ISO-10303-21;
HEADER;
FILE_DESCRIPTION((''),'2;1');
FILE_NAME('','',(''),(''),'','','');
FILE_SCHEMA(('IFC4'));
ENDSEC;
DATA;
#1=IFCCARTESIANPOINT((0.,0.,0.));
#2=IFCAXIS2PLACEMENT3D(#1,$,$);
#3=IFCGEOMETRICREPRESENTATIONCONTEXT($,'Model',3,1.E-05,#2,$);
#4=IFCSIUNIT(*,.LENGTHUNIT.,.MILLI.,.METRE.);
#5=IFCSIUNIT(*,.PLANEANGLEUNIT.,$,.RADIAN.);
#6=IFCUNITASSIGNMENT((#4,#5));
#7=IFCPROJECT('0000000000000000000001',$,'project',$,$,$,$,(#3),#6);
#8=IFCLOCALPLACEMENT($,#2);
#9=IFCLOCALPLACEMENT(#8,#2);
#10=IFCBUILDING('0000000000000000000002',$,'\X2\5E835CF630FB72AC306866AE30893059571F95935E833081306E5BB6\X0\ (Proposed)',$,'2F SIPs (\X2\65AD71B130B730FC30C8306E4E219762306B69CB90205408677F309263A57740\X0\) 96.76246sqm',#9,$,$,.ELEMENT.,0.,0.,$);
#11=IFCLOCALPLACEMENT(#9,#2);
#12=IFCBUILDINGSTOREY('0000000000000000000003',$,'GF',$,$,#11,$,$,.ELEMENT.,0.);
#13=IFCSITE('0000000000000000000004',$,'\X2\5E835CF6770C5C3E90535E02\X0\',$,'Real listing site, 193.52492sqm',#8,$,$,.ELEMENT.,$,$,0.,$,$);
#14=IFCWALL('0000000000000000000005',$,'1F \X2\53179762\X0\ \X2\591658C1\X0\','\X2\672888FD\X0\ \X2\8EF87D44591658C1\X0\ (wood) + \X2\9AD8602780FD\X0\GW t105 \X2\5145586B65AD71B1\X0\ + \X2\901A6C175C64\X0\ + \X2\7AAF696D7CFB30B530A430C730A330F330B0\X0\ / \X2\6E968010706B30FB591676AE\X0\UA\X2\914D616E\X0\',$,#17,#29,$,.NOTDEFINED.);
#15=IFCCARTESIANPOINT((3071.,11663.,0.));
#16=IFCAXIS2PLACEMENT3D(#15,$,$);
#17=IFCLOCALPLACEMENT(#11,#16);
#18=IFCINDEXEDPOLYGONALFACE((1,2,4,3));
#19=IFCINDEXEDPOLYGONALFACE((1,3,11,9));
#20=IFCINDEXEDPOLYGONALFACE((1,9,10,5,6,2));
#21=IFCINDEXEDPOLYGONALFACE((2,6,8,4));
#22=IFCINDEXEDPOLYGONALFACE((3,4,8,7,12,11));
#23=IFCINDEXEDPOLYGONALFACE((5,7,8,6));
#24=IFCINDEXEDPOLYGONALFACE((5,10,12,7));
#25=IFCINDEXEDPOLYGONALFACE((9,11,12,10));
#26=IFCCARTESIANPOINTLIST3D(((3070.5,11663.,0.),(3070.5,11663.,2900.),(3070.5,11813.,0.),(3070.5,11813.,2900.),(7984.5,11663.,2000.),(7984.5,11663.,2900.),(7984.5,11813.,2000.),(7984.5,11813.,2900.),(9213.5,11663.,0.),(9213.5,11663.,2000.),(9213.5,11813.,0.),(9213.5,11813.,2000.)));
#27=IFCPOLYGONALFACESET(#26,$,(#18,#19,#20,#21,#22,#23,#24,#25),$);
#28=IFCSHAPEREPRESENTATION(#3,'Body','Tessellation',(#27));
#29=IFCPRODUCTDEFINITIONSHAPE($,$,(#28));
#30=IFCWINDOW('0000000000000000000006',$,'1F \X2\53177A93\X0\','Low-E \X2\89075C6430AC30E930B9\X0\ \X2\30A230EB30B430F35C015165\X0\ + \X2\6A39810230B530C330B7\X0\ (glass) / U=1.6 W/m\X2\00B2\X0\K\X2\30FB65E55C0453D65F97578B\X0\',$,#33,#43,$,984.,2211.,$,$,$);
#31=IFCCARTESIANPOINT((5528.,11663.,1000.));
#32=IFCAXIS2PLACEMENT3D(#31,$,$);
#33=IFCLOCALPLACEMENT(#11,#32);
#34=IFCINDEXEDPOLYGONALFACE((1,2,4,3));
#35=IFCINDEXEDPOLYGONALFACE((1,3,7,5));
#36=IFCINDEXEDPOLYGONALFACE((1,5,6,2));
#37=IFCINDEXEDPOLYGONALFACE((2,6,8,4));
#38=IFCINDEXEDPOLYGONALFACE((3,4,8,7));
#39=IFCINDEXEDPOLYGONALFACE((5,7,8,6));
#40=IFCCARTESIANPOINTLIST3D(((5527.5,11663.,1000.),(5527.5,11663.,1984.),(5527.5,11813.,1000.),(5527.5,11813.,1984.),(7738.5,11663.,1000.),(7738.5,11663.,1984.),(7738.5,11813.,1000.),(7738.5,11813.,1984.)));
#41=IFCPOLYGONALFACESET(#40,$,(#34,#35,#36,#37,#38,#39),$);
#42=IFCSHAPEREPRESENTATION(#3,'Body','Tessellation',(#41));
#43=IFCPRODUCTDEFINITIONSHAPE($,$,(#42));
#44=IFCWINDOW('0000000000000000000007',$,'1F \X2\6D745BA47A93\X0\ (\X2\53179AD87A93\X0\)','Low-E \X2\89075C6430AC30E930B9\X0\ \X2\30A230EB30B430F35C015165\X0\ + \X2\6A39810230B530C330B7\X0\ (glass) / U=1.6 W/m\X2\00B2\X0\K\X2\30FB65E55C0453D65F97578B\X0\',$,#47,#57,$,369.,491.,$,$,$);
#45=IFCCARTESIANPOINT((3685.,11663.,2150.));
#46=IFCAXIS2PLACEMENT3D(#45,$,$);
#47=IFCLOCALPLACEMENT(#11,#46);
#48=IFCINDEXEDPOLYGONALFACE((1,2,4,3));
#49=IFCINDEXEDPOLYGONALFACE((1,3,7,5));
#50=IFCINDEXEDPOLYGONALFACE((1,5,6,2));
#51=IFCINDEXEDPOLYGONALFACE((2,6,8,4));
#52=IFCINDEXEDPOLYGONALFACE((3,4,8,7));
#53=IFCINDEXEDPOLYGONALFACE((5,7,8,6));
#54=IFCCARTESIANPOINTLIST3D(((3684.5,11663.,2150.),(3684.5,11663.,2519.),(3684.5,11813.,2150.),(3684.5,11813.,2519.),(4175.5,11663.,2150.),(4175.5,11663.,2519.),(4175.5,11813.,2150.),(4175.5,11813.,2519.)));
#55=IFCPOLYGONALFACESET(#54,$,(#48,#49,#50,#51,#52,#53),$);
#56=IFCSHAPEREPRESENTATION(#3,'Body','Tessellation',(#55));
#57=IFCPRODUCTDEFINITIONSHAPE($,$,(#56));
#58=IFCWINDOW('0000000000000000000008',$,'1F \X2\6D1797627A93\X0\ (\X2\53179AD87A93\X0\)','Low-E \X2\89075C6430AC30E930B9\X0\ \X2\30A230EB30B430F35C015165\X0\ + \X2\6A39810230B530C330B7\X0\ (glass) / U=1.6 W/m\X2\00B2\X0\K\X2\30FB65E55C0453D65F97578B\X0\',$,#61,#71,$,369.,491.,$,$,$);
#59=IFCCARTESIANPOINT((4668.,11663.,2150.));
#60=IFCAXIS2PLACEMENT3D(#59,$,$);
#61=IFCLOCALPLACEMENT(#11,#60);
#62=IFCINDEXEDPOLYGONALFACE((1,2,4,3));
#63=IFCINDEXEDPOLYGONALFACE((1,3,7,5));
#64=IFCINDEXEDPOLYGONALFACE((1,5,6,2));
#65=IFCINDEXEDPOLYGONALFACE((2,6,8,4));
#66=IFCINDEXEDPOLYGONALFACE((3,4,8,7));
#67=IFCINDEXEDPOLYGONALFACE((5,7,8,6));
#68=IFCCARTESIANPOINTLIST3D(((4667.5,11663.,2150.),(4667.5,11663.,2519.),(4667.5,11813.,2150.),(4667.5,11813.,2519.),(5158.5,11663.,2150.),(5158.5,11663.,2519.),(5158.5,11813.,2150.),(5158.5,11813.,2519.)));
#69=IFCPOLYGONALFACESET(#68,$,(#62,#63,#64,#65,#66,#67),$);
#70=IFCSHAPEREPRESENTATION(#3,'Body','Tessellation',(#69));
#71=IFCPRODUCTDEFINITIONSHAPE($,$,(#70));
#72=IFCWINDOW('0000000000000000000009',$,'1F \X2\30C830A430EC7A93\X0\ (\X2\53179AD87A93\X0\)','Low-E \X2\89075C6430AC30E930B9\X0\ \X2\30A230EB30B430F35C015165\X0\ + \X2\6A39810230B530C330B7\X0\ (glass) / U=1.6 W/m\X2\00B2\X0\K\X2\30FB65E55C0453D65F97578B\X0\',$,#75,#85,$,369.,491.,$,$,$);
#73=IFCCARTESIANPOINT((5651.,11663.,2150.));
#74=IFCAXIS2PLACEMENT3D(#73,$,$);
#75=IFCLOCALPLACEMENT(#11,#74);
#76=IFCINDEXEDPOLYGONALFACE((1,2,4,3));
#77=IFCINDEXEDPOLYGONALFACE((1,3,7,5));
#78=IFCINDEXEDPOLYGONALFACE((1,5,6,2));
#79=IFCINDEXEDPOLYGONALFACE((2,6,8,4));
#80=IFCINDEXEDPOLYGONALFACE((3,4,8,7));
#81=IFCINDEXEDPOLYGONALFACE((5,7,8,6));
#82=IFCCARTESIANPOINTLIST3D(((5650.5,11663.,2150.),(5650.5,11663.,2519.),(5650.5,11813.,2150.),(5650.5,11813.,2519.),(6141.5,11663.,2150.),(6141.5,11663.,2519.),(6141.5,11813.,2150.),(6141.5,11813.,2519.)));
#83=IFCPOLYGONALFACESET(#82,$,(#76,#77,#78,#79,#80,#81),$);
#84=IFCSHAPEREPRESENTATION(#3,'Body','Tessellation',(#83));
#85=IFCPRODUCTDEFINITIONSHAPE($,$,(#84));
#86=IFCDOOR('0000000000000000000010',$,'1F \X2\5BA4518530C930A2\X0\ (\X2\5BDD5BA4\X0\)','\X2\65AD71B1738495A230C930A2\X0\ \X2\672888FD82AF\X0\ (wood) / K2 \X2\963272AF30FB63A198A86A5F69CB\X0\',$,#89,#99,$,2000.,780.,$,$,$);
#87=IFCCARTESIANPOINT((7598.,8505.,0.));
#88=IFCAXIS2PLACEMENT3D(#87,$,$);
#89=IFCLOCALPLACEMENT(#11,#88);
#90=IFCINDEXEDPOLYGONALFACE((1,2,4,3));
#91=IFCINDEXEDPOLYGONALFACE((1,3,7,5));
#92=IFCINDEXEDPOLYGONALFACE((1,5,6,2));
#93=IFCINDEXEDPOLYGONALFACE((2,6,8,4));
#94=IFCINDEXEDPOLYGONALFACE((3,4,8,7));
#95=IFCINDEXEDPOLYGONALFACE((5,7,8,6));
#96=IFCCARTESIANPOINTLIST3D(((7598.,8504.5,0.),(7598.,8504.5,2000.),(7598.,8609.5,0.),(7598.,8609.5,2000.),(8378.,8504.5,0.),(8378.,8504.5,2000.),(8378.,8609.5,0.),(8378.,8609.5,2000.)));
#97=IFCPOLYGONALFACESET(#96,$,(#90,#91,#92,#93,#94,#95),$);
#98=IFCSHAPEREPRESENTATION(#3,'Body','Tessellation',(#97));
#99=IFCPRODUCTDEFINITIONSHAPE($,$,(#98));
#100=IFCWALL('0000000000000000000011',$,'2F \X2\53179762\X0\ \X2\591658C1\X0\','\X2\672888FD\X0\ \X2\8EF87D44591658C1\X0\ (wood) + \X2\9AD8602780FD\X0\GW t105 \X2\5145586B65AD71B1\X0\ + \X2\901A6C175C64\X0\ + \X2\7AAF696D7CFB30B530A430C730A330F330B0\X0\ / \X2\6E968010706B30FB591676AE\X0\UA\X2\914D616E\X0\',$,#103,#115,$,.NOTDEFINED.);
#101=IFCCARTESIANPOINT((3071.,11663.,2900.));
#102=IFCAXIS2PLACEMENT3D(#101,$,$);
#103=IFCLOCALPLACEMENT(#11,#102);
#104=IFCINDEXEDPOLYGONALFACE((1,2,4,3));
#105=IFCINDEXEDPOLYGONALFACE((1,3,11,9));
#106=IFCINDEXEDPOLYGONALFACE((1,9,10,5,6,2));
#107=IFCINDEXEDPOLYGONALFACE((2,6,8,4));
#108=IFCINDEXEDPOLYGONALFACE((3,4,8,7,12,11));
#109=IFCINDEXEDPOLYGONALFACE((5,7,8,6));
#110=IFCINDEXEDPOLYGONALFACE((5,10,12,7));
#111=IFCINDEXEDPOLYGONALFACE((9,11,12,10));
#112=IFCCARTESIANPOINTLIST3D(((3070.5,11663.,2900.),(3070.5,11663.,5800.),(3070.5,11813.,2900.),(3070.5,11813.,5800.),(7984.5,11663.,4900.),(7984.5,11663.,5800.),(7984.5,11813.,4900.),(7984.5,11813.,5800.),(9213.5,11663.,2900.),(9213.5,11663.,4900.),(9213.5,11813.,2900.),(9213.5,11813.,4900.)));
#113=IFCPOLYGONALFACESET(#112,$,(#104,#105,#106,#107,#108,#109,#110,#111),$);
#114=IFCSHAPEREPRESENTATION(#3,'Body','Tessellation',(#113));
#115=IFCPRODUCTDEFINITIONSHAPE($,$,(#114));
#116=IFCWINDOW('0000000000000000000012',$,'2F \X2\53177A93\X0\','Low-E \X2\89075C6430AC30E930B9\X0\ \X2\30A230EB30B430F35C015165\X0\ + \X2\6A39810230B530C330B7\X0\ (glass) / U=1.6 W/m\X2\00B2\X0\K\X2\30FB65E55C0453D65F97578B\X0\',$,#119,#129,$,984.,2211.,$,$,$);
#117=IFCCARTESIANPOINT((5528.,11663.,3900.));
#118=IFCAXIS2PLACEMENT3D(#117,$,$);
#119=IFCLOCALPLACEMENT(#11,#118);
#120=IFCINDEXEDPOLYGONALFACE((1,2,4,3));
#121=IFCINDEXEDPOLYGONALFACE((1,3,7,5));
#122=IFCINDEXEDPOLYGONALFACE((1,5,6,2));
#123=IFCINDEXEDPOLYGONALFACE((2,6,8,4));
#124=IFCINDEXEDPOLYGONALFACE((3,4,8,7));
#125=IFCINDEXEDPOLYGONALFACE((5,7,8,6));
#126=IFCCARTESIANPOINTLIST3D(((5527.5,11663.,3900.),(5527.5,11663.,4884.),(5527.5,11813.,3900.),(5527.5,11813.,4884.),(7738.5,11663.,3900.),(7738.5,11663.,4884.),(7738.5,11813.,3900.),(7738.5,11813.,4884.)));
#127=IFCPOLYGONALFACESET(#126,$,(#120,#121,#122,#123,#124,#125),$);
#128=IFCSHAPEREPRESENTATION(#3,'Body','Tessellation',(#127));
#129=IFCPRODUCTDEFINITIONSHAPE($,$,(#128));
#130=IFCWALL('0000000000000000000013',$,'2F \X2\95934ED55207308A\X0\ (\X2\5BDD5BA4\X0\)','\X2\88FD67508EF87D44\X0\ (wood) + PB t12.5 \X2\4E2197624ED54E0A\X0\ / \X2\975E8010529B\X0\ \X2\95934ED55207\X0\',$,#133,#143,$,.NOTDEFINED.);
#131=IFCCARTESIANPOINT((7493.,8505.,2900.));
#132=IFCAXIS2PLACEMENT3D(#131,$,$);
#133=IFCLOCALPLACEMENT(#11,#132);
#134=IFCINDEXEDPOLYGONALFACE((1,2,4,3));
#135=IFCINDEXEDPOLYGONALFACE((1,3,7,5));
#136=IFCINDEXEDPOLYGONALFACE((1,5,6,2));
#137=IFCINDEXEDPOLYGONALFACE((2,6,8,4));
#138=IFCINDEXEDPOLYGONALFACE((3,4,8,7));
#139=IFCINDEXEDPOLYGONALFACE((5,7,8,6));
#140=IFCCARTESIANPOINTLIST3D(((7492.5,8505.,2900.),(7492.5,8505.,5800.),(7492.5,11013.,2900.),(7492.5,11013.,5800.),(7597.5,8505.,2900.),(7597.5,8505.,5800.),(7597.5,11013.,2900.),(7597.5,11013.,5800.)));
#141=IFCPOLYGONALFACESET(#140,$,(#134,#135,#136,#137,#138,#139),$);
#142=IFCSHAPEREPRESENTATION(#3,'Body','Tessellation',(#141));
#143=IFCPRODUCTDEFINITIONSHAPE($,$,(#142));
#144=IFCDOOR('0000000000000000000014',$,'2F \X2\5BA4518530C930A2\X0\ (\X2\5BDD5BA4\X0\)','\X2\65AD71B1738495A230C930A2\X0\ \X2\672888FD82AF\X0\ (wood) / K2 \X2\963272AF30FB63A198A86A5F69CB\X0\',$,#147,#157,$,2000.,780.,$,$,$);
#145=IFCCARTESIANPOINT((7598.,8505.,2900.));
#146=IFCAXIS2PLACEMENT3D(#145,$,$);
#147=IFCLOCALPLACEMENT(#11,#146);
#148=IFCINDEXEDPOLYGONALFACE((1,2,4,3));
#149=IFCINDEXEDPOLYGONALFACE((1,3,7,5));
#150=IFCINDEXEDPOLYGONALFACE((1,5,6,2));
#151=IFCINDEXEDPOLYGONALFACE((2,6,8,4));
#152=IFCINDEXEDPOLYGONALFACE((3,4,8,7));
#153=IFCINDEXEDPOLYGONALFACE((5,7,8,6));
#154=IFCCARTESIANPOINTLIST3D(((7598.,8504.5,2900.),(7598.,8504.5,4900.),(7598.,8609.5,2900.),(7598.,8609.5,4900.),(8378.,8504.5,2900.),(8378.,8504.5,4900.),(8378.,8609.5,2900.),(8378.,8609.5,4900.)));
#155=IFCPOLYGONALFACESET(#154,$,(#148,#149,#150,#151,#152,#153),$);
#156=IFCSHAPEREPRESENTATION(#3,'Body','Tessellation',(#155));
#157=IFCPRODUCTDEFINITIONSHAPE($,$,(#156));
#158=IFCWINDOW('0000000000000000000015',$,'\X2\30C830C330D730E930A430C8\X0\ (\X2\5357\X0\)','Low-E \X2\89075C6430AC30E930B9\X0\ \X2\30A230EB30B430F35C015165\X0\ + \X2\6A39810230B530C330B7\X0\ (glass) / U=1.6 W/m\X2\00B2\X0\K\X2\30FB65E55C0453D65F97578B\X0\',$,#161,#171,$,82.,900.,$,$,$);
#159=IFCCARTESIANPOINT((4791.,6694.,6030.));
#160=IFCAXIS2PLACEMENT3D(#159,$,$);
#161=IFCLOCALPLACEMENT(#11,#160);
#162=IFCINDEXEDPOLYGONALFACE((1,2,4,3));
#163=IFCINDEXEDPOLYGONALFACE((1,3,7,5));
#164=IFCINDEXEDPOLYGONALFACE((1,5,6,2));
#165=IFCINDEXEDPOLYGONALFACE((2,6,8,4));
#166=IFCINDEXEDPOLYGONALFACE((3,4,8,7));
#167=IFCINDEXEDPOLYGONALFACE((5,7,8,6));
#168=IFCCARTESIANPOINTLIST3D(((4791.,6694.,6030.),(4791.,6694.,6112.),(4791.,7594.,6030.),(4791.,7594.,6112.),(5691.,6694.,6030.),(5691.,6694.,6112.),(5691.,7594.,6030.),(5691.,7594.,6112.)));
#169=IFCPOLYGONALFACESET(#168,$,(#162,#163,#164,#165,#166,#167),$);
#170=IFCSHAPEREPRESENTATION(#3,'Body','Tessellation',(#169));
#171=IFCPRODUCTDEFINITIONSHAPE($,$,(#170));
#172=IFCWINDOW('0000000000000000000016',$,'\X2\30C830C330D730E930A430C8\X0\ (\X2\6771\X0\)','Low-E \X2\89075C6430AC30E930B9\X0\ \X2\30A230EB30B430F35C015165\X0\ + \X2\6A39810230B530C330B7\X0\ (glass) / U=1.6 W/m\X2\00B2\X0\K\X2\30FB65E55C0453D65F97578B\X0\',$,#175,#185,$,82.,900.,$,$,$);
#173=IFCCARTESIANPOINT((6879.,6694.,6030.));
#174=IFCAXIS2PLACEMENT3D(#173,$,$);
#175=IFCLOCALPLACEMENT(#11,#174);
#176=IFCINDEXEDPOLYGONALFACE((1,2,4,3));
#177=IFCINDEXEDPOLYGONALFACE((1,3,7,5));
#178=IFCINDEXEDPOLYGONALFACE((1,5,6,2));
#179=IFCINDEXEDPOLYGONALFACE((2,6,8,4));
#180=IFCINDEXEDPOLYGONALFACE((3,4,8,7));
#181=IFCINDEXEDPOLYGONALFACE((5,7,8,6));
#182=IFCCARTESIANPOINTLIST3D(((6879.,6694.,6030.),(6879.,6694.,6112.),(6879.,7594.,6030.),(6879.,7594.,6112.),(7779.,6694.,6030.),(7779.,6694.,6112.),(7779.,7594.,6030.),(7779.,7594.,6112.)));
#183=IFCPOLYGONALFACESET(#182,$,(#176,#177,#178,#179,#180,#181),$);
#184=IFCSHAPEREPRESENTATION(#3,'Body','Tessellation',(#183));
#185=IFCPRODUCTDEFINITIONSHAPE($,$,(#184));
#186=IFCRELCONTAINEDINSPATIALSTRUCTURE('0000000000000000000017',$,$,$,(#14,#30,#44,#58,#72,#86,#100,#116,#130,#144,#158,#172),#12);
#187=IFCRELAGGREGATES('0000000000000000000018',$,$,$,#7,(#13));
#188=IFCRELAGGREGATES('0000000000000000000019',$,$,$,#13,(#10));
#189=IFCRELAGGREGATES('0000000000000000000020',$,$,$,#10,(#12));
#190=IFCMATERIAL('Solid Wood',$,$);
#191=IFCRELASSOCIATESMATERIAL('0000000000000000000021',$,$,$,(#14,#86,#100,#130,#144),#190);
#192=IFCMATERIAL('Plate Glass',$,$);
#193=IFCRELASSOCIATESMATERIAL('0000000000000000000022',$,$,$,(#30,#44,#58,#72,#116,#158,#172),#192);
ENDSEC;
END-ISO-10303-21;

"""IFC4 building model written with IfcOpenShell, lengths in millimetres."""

from ifc_helpers import new_model, si_unit, frame, frame_2d, origin, place, context, project, spatial, rectangle, extrude, material, element, fill, save


model = new_model("IFC4")

# Units and contexts
model_context = context("Model", 3, precision=1e-05, world=origin())
ifc_project = project(units=[si_unit("LENGTHUNIT", "METRE", prefix="MILLI"), si_unit("PLANEANGLEUNIT", "RADIAN")], contexts=[model_context])

# Site, building, storey
site_placement = place(None, origin())
site = spatial("IfcSite", under=ifc_project, at=site_placement, Name="広島県尾道市", ObjectType="Real listing site, 193.52492sqm", CompositionType="ELEMENT", RefElevation=0.0)
building_placement = place(site_placement, origin())
building = spatial("IfcBuilding", under=site, at=building_placement, Name="広島・犬と暮らす土間広めの家 (Proposed)", ObjectType="2F SIPs (断熱シートの両面に構造合板を接着) 96.76246sqm", CompositionType="ELEMENT", ElevationOfRefHeight=0.0, ElevationOfTerrain=0.0)
storey_placement = place(building_placement, origin())
storey = spatial("IfcBuildingStorey", under=building, at=storey_placement, Name="GF", CompositionType="ELEMENT", Elevation=0.0)

# Wall, openings, windows
ifc_material_1 = material(Name="Solid Wood")
wall_1_placement = place(storey_placement, frame((3071.0, 11663.0, 0.0)))
wall_1 = element("IfcWall", 1, at=wall_1_placement, inside=storey, material=ifc_material_1, Name="1F 北面 外壁", Description="木製 軸組外壁 (wood) + 高性能GW t105 充填断熱 + 通気層 + 窯業系サイディング / 準耐火・外皮UA配慮", PredefinedType="NOTDEFINED", context=model_context, shape_type="SweptSolid", body=[
    extrude(rectangle(XDim=6143.0, YDim=150.0, at=frame_2d((3071.0, 75.0))), frame((3071.0, 11663.0, 0.0)), (0.0, 0.0, 1.0), 2900.0),
])
opening_1_placement = place(storey_placement, frame((5528.0, 11663.0, 1000.0)))
opening_1 = element("IfcOpeningElement", 2, at=opening_1_placement, cuts=wall_1, PredefinedType="NOTDEFINED", context=model_context, shape_type="SweptSolid", body=[
    extrude(rectangle(XDim=2211.0, YDim=150.0, at=frame_2d((1105.0, 75.0))), frame((5528.0, 11663.0, 1000.0)), (0.0, 0.0, 1.0), 984.0),
])
opening_2_placement = place(storey_placement, frame((3685.0, 11663.0, 2150.0)))
opening_2 = element("IfcOpeningElement", 3, at=opening_2_placement, cuts=wall_1, PredefinedType="NOTDEFINED", context=model_context, shape_type="SweptSolid", body=[
    extrude(rectangle(XDim=491.0, YDim=150.0, at=frame_2d((245.0, 75.0))), frame((3685.0, 11663.0, 2150.0)), (0.0, 0.0, 1.0), 369.0),
])
opening_3_placement = place(storey_placement, frame((4668.0, 11663.0, 2150.0)))
opening_3 = element("IfcOpeningElement", 4, at=opening_3_placement, cuts=wall_1, PredefinedType="NOTDEFINED", context=model_context, shape_type="SweptSolid", body=[
    extrude(rectangle(XDim=491.0, YDim=150.0, at=frame_2d((245.0, 75.0))), frame((4668.0, 11663.0, 2150.0)), (0.0, 0.0, 1.0), 369.0),
])
opening_4_placement = place(storey_placement, frame((5651.0, 11663.0, 2150.0)))
opening_4 = element("IfcOpeningElement", 5, at=opening_4_placement, cuts=wall_1, PredefinedType="NOTDEFINED", context=model_context, shape_type="SweptSolid", body=[
    extrude(rectangle(XDim=491.0, YDim=150.0, at=frame_2d((245.0, 75.0))), frame((5651.0, 11663.0, 2150.0)), (0.0, 0.0, 1.0), 369.0),
])
ifc_material_2 = material(Name="Plate Glass")
window_1_placement = place(storey_placement, frame((5528.0, 11663.0, 1000.0)))
window_1 = element("IfcWindow", 6, at=window_1_placement, inside=storey, material=ifc_material_2, Name="1F 北窓", Description="Low-E 複層ガラス アルゴン封入 + 樹脂サッシ (glass) / U=1.6 W/m²K・日射取得型", OverallHeight=984.0, OverallWidth=2211.0, context=model_context, shape_type="SweptSolid", body=[
    extrude(rectangle(XDim=2211.0, YDim=150.0, at=frame_2d((1105.0, 75.0))), frame((5528.0, 11663.0, 1000.0)), (0.0, 0.0, 1.0), 984.0),
])
fill(opening_1, window_1)
window_2_placement = place(storey_placement, frame((3685.0, 11663.0, 2150.0)))
window_2 = element("IfcWindow", 7, at=window_2_placement, inside=storey, material=ifc_material_2, Name="1F 浴室窓 (北高窓)", Description="Low-E 複層ガラス アルゴン封入 + 樹脂サッシ (glass) / U=1.6 W/m²K・日射取得型", OverallHeight=369.0, OverallWidth=491.0, context=model_context, shape_type="SweptSolid", body=[
    extrude(rectangle(XDim=491.0, YDim=150.0, at=frame_2d((245.0, 75.0))), frame((3685.0, 11663.0, 2150.0)), (0.0, 0.0, 1.0), 369.0),
])
fill(opening_2, window_2)
window_3_placement = place(storey_placement, frame((4668.0, 11663.0, 2150.0)))
window_3 = element("IfcWindow", 8, at=window_3_placement, inside=storey, material=ifc_material_2, Name="1F 洗面窓 (北高窓)", Description="Low-E 複層ガラス アルゴン封入 + 樹脂サッシ (glass) / U=1.6 W/m²K・日射取得型", OverallHeight=369.0, OverallWidth=491.0, context=model_context, shape_type="SweptSolid", body=[
    extrude(rectangle(XDim=491.0, YDim=150.0, at=frame_2d((245.0, 75.0))), frame((4668.0, 11663.0, 2150.0)), (0.0, 0.0, 1.0), 369.0),
])
fill(opening_3, window_3)
window_4_placement = place(storey_placement, frame((5651.0, 11663.0, 2150.0)))
window_4 = element("IfcWindow", 9, at=window_4_placement, inside=storey, material=ifc_material_2, Name="1F トイレ窓 (北高窓)", Description="Low-E 複層ガラス アルゴン封入 + 樹脂サッシ (glass) / U=1.6 W/m²K・日射取得型", OverallHeight=369.0, OverallWidth=491.0, context=model_context, shape_type="SweptSolid", body=[
    extrude(rectangle(XDim=491.0, YDim=150.0, at=frame_2d((245.0, 75.0))), frame((5651.0, 11663.0, 2150.0)), (0.0, 0.0, 1.0), 369.0),
])
fill(opening_4, window_4)

# Door
door_1_placement = place(storey_placement, frame((7598.0, 8505.0, 0.0)))
element("IfcDoor", 10, at=door_1_placement, inside=storey, material=ifc_material_1, Name="1F 室内ドア (寝室)", Description="断熱玄関ドア 木製芯 (wood) / K2 防犯・採風機構", OverallHeight=2000.0, OverallWidth=780.0, context=model_context, shape_type="SweptSolid", body=[
    extrude(rectangle(XDim=780.0, YDim=105.0, at=frame_2d((390.0, 52.0))), frame((7598.0, 8505.0, 0.0)), (0.0, 0.0, 1.0), 2000.0),
])

# Wall, opening, window
wall_2_placement = place(storey_placement, frame((3071.0, 11663.0, 2900.0)))
wall_2 = element("IfcWall", 11, at=wall_2_placement, inside=storey, material=ifc_material_1, Name="2F 北面 外壁", Description="木製 軸組外壁 (wood) + 高性能GW t105 充填断熱 + 通気層 + 窯業系サイディング / 準耐火・外皮UA配慮", PredefinedType="NOTDEFINED", context=model_context, shape_type="SweptSolid", body=[
    extrude(rectangle(XDim=6143.0, YDim=150.0, at=frame_2d((3071.0, 75.0))), frame((3071.0, 11663.0, 2900.0)), (0.0, 0.0, 1.0), 2900.0),
])
opening_5_placement = place(storey_placement, frame((5528.0, 11663.0, 3900.0)))
opening_5 = element("IfcOpeningElement", 12, at=opening_5_placement, cuts=wall_2, PredefinedType="NOTDEFINED", context=model_context, shape_type="SweptSolid", body=[
    extrude(rectangle(XDim=2211.0, YDim=150.0, at=frame_2d((1105.0, 75.0))), frame((5528.0, 11663.0, 3900.0)), (0.0, 0.0, 1.0), 984.0),
])
window_5_placement = place(storey_placement, frame((5528.0, 11663.0, 3900.0)))
window_5 = element("IfcWindow", 13, at=window_5_placement, inside=storey, material=ifc_material_2, Name="2F 北窓", Description="Low-E 複層ガラス アルゴン封入 + 樹脂サッシ (glass) / U=1.6 W/m²K・日射取得型", OverallHeight=984.0, OverallWidth=2211.0, context=model_context, shape_type="SweptSolid", body=[
    extrude(rectangle(XDim=2211.0, YDim=150.0, at=frame_2d((1105.0, 75.0))), frame((5528.0, 11663.0, 3900.0)), (0.0, 0.0, 1.0), 984.0),
])
fill(opening_5, window_5)

# Wall
wall_3_placement = place(storey_placement, frame((7493.0, 8505.0, 2900.0)))
element("IfcWall", 14, at=wall_3_placement, inside=storey, material=ifc_material_1, Name="2F 間仕切り (寝室)", Description="製材軸組 (wood) + PB t12.5 両面仕上 / 非耐力 間仕切", PredefinedType="NOTDEFINED", context=model_context, shape_type="SweptSolid", body=[
    extrude(rectangle(XDim=105.0, YDim=2508.0, at=frame_2d((52.0, 1254.0))), frame((7493.0, 8505.0, 2900.0)), (0.0, 0.0, 1.0), 2900.0),
])

# Door
door_2_placement = place(storey_placement, frame((7598.0, 8505.0, 2900.0)))
element("IfcDoor", 15, at=door_2_placement, inside=storey, material=ifc_material_1, Name="2F 室内ドア (寝室)", Description="断熱玄関ドア 木製芯 (wood) / K2 防犯・採風機構", OverallHeight=2000.0, OverallWidth=780.0, context=model_context, shape_type="SweptSolid", body=[
    extrude(rectangle(XDim=780.0, YDim=105.0, at=frame_2d((390.0, 52.0))), frame((7598.0, 8505.0, 2900.0)), (0.0, 0.0, 1.0), 2000.0),
])

# Windows
window_6_placement = place(storey_placement, frame((4791.0, 6694.0, 6030.0)))
element("IfcWindow", 16, at=window_6_placement, inside=storey, material=ifc_material_2, Name="トップライト (南)", Description="Low-E 複層ガラス アルゴン封入 + 樹脂サッシ (glass) / U=1.6 W/m²K・日射取得型", OverallHeight=82.0, OverallWidth=900.0, context=model_context, shape_type="SweptSolid", body=[
    extrude(rectangle(XDim=900.0, YDim=900.0, at=frame_2d((450.0, 450.0))), frame((4791.0, 6694.0, 6030.0)), (0.0, 0.0, 1.0), 82.0),
])
window_7_placement = place(storey_placement, frame((6879.0, 6694.0, 6030.0)))
element("IfcWindow", 17, at=window_7_placement, inside=storey, material=ifc_material_2, Name="トップライト (東)", Description="Low-E 複層ガラス アルゴン封入 + 樹脂サッシ (glass) / U=1.6 W/m²K・日射取得型", OverallHeight=82.0, OverallWidth=900.0, context=model_context, shape_type="SweptSolid", body=[
    extrude(rectangle(XDim=900.0, YDim=900.0, at=frame_2d((450.0, 450.0))), frame((6879.0, 6694.0, 6030.0)), (0.0, 0.0, 1.0), 82.0),
])

save(model, "model.ifc")
